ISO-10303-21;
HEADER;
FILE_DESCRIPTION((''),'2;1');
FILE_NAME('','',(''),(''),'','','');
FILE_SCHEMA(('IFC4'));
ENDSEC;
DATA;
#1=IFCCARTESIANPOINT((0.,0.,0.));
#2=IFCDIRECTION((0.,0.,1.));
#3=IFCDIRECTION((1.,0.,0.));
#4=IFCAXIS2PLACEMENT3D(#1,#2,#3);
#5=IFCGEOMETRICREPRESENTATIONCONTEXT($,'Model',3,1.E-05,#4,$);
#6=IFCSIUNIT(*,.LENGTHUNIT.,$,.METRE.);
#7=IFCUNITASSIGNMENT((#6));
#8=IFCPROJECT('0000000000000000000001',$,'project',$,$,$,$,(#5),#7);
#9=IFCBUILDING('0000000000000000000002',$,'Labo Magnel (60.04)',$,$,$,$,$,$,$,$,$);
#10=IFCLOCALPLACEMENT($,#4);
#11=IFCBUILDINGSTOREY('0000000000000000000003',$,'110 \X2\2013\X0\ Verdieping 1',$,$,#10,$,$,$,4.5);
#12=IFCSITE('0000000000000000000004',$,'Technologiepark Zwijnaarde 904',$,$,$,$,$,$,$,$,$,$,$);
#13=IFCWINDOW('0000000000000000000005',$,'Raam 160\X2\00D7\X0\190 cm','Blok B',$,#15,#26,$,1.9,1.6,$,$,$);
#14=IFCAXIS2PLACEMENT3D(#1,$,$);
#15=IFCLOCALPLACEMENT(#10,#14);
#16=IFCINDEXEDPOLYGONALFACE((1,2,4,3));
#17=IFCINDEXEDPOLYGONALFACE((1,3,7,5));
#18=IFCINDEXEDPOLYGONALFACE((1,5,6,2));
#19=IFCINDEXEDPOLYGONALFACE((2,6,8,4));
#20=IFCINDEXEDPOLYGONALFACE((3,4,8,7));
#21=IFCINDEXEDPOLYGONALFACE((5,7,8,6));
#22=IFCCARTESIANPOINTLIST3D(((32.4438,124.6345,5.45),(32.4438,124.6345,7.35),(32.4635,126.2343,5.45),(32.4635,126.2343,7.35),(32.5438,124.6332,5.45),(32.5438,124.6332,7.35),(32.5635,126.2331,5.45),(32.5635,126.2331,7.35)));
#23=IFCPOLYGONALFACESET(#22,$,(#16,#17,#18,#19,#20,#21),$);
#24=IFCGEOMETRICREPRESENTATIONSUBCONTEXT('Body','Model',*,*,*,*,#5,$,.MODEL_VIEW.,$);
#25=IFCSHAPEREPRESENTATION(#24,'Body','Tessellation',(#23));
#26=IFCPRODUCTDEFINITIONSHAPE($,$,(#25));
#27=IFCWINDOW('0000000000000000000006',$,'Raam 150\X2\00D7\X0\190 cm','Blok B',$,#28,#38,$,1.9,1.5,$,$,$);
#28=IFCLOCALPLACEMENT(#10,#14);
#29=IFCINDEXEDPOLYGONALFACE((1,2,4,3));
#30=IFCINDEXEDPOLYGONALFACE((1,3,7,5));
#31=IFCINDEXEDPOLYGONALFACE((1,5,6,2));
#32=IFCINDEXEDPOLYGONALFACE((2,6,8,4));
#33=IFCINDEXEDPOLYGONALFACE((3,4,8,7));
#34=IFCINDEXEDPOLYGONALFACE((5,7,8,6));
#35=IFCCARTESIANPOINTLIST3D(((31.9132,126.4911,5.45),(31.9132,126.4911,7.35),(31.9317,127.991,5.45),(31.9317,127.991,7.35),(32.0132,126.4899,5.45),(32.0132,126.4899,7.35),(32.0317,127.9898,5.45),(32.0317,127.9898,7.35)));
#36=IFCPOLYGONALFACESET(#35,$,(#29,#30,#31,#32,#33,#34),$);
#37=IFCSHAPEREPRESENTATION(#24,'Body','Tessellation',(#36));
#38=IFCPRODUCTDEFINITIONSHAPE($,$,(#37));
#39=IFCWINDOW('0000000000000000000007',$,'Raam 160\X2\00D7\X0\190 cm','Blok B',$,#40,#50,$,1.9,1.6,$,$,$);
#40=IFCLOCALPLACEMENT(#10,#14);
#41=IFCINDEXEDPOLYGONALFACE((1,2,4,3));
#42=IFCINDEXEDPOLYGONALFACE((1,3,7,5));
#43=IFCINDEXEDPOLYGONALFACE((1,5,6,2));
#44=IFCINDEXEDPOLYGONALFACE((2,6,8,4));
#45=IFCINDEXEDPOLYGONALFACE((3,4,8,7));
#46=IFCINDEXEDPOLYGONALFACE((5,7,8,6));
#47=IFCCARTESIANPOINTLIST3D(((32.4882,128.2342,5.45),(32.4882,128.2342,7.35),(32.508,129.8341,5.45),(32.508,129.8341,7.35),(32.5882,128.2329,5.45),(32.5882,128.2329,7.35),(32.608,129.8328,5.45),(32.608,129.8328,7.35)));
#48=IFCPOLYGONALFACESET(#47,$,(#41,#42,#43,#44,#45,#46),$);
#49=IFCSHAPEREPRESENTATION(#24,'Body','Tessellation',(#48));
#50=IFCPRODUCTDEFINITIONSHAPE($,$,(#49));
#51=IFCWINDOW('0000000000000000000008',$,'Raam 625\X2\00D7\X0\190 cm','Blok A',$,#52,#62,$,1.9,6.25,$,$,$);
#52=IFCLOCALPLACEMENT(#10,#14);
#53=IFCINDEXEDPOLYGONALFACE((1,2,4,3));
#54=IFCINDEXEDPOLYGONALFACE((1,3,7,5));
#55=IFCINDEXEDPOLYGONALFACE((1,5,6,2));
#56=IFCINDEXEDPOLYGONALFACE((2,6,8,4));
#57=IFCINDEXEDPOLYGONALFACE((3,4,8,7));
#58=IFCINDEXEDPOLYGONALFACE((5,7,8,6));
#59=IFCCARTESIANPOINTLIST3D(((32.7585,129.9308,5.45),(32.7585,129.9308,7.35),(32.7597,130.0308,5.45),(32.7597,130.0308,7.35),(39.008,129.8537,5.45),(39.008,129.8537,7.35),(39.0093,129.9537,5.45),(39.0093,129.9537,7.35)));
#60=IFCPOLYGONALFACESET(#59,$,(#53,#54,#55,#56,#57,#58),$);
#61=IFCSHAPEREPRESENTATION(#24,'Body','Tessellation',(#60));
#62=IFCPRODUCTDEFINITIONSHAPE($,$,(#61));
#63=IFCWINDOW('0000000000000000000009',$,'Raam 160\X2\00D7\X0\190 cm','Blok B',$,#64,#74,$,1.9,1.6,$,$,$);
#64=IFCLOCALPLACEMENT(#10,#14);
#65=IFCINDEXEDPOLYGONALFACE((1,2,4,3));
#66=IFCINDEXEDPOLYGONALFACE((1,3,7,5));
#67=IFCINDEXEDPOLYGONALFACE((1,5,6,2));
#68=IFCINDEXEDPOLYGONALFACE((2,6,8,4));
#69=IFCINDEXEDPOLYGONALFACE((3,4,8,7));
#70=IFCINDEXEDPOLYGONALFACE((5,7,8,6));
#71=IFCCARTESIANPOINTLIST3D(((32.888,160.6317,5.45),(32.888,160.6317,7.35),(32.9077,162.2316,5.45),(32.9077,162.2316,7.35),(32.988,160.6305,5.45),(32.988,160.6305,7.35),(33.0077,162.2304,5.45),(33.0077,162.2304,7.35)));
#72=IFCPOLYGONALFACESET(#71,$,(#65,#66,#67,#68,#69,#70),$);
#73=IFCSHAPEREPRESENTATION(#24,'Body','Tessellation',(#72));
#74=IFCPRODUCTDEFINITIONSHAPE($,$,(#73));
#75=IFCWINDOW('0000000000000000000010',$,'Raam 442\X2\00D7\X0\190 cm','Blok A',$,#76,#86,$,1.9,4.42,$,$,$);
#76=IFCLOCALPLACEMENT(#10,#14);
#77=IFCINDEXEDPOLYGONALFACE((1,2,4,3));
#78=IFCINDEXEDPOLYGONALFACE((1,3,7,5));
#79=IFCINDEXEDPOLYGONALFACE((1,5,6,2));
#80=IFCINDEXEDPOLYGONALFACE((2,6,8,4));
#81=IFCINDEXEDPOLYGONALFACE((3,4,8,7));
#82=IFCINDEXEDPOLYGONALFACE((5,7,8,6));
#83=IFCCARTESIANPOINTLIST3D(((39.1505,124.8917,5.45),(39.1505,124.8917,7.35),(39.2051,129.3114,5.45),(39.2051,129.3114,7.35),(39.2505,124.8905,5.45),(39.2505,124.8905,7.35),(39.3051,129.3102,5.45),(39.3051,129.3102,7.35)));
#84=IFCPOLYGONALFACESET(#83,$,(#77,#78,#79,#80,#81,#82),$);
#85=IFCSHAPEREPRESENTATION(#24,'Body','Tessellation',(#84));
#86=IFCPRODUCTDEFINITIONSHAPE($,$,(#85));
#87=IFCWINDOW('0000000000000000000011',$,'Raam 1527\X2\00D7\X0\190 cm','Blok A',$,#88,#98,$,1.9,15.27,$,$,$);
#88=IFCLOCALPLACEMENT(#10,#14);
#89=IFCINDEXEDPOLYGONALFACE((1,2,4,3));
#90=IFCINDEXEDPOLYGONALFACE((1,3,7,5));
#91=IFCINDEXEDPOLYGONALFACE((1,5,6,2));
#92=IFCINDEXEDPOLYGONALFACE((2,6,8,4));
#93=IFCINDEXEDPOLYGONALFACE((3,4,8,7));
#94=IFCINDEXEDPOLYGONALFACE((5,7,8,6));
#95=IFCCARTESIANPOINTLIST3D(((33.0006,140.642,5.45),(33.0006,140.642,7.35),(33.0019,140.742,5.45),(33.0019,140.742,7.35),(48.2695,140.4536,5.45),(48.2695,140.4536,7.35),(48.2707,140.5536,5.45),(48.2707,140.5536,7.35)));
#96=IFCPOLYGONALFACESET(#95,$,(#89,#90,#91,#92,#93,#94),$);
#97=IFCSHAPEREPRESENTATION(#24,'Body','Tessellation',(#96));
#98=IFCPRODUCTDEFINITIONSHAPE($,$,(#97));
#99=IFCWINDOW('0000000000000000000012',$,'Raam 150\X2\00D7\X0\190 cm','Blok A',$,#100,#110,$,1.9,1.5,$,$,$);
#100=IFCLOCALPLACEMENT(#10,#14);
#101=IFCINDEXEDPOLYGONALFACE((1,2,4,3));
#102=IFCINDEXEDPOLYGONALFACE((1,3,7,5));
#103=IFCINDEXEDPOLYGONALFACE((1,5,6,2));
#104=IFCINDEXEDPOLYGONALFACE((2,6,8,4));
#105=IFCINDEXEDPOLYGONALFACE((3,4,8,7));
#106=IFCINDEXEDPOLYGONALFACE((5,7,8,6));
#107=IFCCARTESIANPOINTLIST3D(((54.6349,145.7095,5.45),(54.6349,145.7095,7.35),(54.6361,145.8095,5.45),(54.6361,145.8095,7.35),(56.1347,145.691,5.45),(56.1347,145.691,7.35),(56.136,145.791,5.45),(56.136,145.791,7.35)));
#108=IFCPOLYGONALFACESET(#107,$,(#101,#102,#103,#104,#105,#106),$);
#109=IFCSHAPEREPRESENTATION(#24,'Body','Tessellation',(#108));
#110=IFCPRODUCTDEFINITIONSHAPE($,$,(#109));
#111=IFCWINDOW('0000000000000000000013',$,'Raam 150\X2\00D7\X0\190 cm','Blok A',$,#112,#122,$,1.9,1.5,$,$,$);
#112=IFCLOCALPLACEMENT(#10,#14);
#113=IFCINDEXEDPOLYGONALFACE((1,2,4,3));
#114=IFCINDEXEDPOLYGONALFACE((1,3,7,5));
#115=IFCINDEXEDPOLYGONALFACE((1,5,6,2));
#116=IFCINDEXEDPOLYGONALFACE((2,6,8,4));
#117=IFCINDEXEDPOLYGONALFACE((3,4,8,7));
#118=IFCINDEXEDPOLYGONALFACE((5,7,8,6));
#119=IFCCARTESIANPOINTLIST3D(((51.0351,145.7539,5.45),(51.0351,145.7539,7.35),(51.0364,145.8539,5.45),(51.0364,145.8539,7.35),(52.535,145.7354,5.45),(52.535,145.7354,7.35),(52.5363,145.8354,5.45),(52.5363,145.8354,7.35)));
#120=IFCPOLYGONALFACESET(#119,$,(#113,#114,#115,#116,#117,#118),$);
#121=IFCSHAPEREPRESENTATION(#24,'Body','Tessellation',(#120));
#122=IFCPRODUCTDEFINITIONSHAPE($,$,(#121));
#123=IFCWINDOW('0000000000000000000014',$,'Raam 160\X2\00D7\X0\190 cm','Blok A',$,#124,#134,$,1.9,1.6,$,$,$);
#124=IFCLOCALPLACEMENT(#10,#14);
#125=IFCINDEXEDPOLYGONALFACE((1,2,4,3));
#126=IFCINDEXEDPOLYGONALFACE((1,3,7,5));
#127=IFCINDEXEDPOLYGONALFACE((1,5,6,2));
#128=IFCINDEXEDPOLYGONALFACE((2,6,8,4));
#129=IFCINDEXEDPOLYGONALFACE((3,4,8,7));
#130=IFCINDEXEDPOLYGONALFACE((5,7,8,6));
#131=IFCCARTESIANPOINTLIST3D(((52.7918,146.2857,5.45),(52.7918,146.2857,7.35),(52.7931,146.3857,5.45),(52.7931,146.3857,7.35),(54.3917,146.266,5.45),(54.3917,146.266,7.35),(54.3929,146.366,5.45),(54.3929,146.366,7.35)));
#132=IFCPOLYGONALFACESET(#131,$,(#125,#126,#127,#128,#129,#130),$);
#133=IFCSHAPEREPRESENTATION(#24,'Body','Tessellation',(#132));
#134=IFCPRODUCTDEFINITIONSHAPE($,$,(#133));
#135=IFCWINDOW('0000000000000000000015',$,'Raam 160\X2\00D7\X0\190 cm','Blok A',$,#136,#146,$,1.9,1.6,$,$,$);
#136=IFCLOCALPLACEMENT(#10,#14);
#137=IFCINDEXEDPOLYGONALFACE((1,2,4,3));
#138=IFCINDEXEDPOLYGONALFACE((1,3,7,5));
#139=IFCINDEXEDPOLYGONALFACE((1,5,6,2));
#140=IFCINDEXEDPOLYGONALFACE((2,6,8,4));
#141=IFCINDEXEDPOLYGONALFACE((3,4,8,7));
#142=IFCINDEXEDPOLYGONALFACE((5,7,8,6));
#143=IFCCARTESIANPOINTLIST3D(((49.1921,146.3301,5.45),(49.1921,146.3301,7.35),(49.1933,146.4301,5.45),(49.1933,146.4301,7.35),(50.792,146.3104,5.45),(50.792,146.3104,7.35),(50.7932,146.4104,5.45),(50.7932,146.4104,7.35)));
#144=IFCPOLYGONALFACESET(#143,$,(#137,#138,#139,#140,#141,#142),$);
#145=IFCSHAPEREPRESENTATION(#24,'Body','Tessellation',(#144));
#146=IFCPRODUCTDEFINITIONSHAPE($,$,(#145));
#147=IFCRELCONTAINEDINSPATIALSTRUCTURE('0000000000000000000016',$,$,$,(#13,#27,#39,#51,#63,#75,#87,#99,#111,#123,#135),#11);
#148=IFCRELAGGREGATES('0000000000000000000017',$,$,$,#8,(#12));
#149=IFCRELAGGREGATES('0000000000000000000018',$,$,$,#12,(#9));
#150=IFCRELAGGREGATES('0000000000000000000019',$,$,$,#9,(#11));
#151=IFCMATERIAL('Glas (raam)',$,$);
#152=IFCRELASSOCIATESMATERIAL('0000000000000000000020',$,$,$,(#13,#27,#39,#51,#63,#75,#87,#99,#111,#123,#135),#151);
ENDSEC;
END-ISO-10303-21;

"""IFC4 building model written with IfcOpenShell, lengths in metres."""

from ifc_helpers import new_model, si_unit, frame, origin, origin_with_axes, place, context, subcontext, project, spatial, polyline, outline, extrude, material, element, save


model = new_model("IFC4")

# Units and contexts
model_context = context("Model", 3, precision=1e-05, world=origin_with_axes())
body_context = subcontext(model_context, "Body", "Model", "MODEL_VIEW")
ifc_project = project(units=[si_unit("LENGTHUNIT", "METRE")], contexts=[model_context])

# Site, building, storey
site = spatial("IfcSite", under=ifc_project, Name="Technologiepark Zwijnaarde 904")
building = spatial("IfcBuilding", under=site, Name="Labo Magnel (60.04)")
storey_placement = place(None, origin_with_axes())
storey = spatial("IfcBuildingStorey", under=building, at=storey_placement, Name="110 – Verdieping 1", Elevation=4.5)

# Windows
ifc_material_1 = material(Name="Glas (raam)")
window_1_placement = place(storey_placement, frame((32.4938, 124.6338, 5.45), z_axis=(0.0, 0.0, 1.0), x_axis=(0.012338, 0.999924, 0.0)))
element("IfcWindow", 1, at=window_1_placement, inside=storey, material=ifc_material_1, Name="Raam 160×190 cm", Description="Blok B", OverallHeight=1.9, OverallWidth=1.6, context=body_context, shape_type="SweptSolid", body=[
    extrude(outline(polyline([(0.0, -0.05), (1.6, -0.05), (1.6, 0.05), (0.0, 0.05), (0.0, -0.05)])), origin(), (0.0, 0.0, 1.0), 1.9),
])
window_2_placement = place(storey_placement, frame((31.9632, 126.4905, 5.45), z_axis=(0.0, 0.0, 1.0), x_axis=(0.012338, 0.999924, 0.0)))
element("IfcWindow", 2, at=window_2_placement, inside=storey, material=ifc_material_1, Name="Raam 150×190 cm", Description="Blok B", OverallHeight=1.9, OverallWidth=1.5, context=body_context, shape_type="SweptSolid", body=[
    extrude(outline(polyline([(0.0, -0.05), (1.5, -0.05), (1.5, 0.05), (0.0, 0.05), (0.0, -0.05)])), origin(), (0.0, 0.0, 1.0), 1.9),
])
window_3_placement = place(storey_placement, frame((32.5382, 128.2336, 5.45), z_axis=(0.0, 0.0, 1.0), x_axis=(0.012338, 0.999924, 0.0)))
element("IfcWindow", 3, at=window_3_placement, inside=storey, material=ifc_material_1, Name="Raam 160×190 cm", Description="Blok B", OverallHeight=1.9, OverallWidth=1.6, context=body_context, shape_type="SweptSolid", body=[
    extrude(outline(polyline([(0.0, -0.05), (1.6, -0.05), (1.6, 0.05), (0.0, 0.05), (0.0, -0.05)])), origin(), (0.0, 0.0, 1.0), 1.9),
])
window_4_placement = place(storey_placement, frame((39.0086, 129.9037, 5.45), z_axis=(0.0, 0.0, 1.0), x_axis=(-0.999924, 0.012338, 0.0)))
element("IfcWindow", 4, at=window_4_placement, inside=storey, material=ifc_material_1, Name="Raam 625×190 cm", Description="Blok A", OverallHeight=1.9, OverallWidth=6.25, context=body_context, shape_type="SweptSolid", body=[
    extrude(outline(polyline([(0.0, -0.05), (6.25, -0.05), (6.25, 0.05), (0.0, 0.05), (0.0, -0.05)])), origin(), (0.0, 0.0, 1.0), 1.9),
])
window_5_placement = place(storey_placement, frame((32.938, 160.6311, 5.45), z_axis=(0.0, 0.0, 1.0), x_axis=(0.012338, 0.999924, 0.0)))
element("IfcWindow", 5, at=window_5_placement, inside=storey, material=ifc_material_1, Name="Raam 160×190 cm", Description="Blok B", OverallHeight=1.9, OverallWidth=1.6, context=body_context, shape_type="SweptSolid", body=[
    extrude(outline(polyline([(0.0, -0.05), (1.6, -0.05), (1.6, 0.05), (0.0, 0.05), (0.0, -0.05)])), origin(), (0.0, 0.0, 1.0), 1.9),
])
window_6_placement = place(storey_placement, frame((39.2005, 124.8911, 5.45), z_axis=(0.0, 0.0, 1.0), x_axis=(0.012338, 0.999924, 0.0)))
element("IfcWindow", 6, at=window_6_placement, inside=storey, material=ifc_material_1, Name="Raam 442×190 cm", Description="Blok A", OverallHeight=1.9, OverallWidth=4.42, context=body_context, shape_type="SweptSolid", body=[
    extrude(outline(polyline([(0.0, -0.05), (4.42, -0.05), (4.42, 0.05), (0.0, 0.05), (0.0, -0.05)])), origin(), (0.0, 0.0, 1.0), 1.9),
])
window_7_placement = place(storey_placement, frame((48.2701, 140.5036, 5.45), z_axis=(0.0, 0.0, 1.0), x_axis=(-0.999924, 0.012338, 0.0)))
element("IfcWindow", 7, at=window_7_placement, inside=storey, material=ifc_material_1, Name="Raam 1527×190 cm", Description="Blok A", OverallHeight=1.9, OverallWidth=15.27, context=body_context, shape_type="SweptSolid", body=[
    extrude(outline(polyline([(0.0, -0.05), (15.27, -0.05), (15.27, 0.05), (0.0, 0.05), (0.0, -0.05)])), origin(), (0.0, 0.0, 1.0), 1.9),
])
window_8_placement = place(storey_placement, frame((56.1354, 145.741, 5.45), z_axis=(0.0, 0.0, 1.0), x_axis=(-0.999924, 0.012338, 0.0)))
element("IfcWindow", 8, at=window_8_placement, inside=storey, material=ifc_material_1, Name="Raam 150×190 cm", Description="Blok A", OverallHeight=1.9, OverallWidth=1.5, context=body_context, shape_type="SweptSolid", body=[
    extrude(outline(polyline([(0.0, -0.05), (1.5, -0.05), (1.5, 0.05), (0.0, 0.05), (0.0, -0.05)])), origin(), (0.0, 0.0, 1.0), 1.9),
])
window_9_placement = place(storey_placement, frame((52.5356, 145.7854, 5.45), z_axis=(0.0, 0.0, 1.0), x_axis=(-0.999924, 0.012338, 0.0)))
element("IfcWindow", 9, at=window_9_placement, inside=storey, material=ifc_material_1, Name="Raam 150×190 cm", Description="Blok A", OverallHeight=1.9, OverallWidth=1.5, context=body_context, shape_type="SweptSolid", body=[
    extrude(outline(polyline([(0.0, -0.05), (1.5, -0.05), (1.5, 0.05), (0.0, 0.05), (0.0, -0.05)])), origin(), (0.0, 0.0, 1.0), 1.9),
])
window_10_placement = place(storey_placement, frame((52.7924, 146.3357, 5.45), z_axis=(0.0, 0.0, 1.0), x_axis=(0.999924, -0.012338, 0.0)))
element("IfcWindow", 10, at=window_10_placement, inside=storey, material=ifc_material_1, Name="Raam 160×190 cm", Description="Blok A", OverallHeight=1.9, OverallWidth=1.6, context=body_context, shape_type="SweptSolid", body=[
    extrude(outline(polyline([(0.0, -0.05), (1.6, -0.05), (1.6, 0.05), (0.0, 0.05), (0.0, -0.05)])), origin(), (0.0, 0.0, 1.0), 1.9),
])
window_11_placement = place(storey_placement, frame((49.1927, 146.3801, 5.45), z_axis=(0.0, 0.0, 1.0), x_axis=(0.999924, -0.012338, 0.0)))
element("IfcWindow", 11, at=window_11_placement, inside=storey, material=ifc_material_1, Name="Raam 160×190 cm", Description="Blok A", OverallHeight=1.9, OverallWidth=1.6, context=body_context, shape_type="SweptSolid", body=[
    extrude(outline(polyline([(0.0, -0.05), (1.6, -0.05), (1.6, 0.05), (0.0, 0.05), (0.0, -0.05)])), origin(), (0.0, 0.0, 1.0), 1.9),
])

save(model, "model.ifc")
